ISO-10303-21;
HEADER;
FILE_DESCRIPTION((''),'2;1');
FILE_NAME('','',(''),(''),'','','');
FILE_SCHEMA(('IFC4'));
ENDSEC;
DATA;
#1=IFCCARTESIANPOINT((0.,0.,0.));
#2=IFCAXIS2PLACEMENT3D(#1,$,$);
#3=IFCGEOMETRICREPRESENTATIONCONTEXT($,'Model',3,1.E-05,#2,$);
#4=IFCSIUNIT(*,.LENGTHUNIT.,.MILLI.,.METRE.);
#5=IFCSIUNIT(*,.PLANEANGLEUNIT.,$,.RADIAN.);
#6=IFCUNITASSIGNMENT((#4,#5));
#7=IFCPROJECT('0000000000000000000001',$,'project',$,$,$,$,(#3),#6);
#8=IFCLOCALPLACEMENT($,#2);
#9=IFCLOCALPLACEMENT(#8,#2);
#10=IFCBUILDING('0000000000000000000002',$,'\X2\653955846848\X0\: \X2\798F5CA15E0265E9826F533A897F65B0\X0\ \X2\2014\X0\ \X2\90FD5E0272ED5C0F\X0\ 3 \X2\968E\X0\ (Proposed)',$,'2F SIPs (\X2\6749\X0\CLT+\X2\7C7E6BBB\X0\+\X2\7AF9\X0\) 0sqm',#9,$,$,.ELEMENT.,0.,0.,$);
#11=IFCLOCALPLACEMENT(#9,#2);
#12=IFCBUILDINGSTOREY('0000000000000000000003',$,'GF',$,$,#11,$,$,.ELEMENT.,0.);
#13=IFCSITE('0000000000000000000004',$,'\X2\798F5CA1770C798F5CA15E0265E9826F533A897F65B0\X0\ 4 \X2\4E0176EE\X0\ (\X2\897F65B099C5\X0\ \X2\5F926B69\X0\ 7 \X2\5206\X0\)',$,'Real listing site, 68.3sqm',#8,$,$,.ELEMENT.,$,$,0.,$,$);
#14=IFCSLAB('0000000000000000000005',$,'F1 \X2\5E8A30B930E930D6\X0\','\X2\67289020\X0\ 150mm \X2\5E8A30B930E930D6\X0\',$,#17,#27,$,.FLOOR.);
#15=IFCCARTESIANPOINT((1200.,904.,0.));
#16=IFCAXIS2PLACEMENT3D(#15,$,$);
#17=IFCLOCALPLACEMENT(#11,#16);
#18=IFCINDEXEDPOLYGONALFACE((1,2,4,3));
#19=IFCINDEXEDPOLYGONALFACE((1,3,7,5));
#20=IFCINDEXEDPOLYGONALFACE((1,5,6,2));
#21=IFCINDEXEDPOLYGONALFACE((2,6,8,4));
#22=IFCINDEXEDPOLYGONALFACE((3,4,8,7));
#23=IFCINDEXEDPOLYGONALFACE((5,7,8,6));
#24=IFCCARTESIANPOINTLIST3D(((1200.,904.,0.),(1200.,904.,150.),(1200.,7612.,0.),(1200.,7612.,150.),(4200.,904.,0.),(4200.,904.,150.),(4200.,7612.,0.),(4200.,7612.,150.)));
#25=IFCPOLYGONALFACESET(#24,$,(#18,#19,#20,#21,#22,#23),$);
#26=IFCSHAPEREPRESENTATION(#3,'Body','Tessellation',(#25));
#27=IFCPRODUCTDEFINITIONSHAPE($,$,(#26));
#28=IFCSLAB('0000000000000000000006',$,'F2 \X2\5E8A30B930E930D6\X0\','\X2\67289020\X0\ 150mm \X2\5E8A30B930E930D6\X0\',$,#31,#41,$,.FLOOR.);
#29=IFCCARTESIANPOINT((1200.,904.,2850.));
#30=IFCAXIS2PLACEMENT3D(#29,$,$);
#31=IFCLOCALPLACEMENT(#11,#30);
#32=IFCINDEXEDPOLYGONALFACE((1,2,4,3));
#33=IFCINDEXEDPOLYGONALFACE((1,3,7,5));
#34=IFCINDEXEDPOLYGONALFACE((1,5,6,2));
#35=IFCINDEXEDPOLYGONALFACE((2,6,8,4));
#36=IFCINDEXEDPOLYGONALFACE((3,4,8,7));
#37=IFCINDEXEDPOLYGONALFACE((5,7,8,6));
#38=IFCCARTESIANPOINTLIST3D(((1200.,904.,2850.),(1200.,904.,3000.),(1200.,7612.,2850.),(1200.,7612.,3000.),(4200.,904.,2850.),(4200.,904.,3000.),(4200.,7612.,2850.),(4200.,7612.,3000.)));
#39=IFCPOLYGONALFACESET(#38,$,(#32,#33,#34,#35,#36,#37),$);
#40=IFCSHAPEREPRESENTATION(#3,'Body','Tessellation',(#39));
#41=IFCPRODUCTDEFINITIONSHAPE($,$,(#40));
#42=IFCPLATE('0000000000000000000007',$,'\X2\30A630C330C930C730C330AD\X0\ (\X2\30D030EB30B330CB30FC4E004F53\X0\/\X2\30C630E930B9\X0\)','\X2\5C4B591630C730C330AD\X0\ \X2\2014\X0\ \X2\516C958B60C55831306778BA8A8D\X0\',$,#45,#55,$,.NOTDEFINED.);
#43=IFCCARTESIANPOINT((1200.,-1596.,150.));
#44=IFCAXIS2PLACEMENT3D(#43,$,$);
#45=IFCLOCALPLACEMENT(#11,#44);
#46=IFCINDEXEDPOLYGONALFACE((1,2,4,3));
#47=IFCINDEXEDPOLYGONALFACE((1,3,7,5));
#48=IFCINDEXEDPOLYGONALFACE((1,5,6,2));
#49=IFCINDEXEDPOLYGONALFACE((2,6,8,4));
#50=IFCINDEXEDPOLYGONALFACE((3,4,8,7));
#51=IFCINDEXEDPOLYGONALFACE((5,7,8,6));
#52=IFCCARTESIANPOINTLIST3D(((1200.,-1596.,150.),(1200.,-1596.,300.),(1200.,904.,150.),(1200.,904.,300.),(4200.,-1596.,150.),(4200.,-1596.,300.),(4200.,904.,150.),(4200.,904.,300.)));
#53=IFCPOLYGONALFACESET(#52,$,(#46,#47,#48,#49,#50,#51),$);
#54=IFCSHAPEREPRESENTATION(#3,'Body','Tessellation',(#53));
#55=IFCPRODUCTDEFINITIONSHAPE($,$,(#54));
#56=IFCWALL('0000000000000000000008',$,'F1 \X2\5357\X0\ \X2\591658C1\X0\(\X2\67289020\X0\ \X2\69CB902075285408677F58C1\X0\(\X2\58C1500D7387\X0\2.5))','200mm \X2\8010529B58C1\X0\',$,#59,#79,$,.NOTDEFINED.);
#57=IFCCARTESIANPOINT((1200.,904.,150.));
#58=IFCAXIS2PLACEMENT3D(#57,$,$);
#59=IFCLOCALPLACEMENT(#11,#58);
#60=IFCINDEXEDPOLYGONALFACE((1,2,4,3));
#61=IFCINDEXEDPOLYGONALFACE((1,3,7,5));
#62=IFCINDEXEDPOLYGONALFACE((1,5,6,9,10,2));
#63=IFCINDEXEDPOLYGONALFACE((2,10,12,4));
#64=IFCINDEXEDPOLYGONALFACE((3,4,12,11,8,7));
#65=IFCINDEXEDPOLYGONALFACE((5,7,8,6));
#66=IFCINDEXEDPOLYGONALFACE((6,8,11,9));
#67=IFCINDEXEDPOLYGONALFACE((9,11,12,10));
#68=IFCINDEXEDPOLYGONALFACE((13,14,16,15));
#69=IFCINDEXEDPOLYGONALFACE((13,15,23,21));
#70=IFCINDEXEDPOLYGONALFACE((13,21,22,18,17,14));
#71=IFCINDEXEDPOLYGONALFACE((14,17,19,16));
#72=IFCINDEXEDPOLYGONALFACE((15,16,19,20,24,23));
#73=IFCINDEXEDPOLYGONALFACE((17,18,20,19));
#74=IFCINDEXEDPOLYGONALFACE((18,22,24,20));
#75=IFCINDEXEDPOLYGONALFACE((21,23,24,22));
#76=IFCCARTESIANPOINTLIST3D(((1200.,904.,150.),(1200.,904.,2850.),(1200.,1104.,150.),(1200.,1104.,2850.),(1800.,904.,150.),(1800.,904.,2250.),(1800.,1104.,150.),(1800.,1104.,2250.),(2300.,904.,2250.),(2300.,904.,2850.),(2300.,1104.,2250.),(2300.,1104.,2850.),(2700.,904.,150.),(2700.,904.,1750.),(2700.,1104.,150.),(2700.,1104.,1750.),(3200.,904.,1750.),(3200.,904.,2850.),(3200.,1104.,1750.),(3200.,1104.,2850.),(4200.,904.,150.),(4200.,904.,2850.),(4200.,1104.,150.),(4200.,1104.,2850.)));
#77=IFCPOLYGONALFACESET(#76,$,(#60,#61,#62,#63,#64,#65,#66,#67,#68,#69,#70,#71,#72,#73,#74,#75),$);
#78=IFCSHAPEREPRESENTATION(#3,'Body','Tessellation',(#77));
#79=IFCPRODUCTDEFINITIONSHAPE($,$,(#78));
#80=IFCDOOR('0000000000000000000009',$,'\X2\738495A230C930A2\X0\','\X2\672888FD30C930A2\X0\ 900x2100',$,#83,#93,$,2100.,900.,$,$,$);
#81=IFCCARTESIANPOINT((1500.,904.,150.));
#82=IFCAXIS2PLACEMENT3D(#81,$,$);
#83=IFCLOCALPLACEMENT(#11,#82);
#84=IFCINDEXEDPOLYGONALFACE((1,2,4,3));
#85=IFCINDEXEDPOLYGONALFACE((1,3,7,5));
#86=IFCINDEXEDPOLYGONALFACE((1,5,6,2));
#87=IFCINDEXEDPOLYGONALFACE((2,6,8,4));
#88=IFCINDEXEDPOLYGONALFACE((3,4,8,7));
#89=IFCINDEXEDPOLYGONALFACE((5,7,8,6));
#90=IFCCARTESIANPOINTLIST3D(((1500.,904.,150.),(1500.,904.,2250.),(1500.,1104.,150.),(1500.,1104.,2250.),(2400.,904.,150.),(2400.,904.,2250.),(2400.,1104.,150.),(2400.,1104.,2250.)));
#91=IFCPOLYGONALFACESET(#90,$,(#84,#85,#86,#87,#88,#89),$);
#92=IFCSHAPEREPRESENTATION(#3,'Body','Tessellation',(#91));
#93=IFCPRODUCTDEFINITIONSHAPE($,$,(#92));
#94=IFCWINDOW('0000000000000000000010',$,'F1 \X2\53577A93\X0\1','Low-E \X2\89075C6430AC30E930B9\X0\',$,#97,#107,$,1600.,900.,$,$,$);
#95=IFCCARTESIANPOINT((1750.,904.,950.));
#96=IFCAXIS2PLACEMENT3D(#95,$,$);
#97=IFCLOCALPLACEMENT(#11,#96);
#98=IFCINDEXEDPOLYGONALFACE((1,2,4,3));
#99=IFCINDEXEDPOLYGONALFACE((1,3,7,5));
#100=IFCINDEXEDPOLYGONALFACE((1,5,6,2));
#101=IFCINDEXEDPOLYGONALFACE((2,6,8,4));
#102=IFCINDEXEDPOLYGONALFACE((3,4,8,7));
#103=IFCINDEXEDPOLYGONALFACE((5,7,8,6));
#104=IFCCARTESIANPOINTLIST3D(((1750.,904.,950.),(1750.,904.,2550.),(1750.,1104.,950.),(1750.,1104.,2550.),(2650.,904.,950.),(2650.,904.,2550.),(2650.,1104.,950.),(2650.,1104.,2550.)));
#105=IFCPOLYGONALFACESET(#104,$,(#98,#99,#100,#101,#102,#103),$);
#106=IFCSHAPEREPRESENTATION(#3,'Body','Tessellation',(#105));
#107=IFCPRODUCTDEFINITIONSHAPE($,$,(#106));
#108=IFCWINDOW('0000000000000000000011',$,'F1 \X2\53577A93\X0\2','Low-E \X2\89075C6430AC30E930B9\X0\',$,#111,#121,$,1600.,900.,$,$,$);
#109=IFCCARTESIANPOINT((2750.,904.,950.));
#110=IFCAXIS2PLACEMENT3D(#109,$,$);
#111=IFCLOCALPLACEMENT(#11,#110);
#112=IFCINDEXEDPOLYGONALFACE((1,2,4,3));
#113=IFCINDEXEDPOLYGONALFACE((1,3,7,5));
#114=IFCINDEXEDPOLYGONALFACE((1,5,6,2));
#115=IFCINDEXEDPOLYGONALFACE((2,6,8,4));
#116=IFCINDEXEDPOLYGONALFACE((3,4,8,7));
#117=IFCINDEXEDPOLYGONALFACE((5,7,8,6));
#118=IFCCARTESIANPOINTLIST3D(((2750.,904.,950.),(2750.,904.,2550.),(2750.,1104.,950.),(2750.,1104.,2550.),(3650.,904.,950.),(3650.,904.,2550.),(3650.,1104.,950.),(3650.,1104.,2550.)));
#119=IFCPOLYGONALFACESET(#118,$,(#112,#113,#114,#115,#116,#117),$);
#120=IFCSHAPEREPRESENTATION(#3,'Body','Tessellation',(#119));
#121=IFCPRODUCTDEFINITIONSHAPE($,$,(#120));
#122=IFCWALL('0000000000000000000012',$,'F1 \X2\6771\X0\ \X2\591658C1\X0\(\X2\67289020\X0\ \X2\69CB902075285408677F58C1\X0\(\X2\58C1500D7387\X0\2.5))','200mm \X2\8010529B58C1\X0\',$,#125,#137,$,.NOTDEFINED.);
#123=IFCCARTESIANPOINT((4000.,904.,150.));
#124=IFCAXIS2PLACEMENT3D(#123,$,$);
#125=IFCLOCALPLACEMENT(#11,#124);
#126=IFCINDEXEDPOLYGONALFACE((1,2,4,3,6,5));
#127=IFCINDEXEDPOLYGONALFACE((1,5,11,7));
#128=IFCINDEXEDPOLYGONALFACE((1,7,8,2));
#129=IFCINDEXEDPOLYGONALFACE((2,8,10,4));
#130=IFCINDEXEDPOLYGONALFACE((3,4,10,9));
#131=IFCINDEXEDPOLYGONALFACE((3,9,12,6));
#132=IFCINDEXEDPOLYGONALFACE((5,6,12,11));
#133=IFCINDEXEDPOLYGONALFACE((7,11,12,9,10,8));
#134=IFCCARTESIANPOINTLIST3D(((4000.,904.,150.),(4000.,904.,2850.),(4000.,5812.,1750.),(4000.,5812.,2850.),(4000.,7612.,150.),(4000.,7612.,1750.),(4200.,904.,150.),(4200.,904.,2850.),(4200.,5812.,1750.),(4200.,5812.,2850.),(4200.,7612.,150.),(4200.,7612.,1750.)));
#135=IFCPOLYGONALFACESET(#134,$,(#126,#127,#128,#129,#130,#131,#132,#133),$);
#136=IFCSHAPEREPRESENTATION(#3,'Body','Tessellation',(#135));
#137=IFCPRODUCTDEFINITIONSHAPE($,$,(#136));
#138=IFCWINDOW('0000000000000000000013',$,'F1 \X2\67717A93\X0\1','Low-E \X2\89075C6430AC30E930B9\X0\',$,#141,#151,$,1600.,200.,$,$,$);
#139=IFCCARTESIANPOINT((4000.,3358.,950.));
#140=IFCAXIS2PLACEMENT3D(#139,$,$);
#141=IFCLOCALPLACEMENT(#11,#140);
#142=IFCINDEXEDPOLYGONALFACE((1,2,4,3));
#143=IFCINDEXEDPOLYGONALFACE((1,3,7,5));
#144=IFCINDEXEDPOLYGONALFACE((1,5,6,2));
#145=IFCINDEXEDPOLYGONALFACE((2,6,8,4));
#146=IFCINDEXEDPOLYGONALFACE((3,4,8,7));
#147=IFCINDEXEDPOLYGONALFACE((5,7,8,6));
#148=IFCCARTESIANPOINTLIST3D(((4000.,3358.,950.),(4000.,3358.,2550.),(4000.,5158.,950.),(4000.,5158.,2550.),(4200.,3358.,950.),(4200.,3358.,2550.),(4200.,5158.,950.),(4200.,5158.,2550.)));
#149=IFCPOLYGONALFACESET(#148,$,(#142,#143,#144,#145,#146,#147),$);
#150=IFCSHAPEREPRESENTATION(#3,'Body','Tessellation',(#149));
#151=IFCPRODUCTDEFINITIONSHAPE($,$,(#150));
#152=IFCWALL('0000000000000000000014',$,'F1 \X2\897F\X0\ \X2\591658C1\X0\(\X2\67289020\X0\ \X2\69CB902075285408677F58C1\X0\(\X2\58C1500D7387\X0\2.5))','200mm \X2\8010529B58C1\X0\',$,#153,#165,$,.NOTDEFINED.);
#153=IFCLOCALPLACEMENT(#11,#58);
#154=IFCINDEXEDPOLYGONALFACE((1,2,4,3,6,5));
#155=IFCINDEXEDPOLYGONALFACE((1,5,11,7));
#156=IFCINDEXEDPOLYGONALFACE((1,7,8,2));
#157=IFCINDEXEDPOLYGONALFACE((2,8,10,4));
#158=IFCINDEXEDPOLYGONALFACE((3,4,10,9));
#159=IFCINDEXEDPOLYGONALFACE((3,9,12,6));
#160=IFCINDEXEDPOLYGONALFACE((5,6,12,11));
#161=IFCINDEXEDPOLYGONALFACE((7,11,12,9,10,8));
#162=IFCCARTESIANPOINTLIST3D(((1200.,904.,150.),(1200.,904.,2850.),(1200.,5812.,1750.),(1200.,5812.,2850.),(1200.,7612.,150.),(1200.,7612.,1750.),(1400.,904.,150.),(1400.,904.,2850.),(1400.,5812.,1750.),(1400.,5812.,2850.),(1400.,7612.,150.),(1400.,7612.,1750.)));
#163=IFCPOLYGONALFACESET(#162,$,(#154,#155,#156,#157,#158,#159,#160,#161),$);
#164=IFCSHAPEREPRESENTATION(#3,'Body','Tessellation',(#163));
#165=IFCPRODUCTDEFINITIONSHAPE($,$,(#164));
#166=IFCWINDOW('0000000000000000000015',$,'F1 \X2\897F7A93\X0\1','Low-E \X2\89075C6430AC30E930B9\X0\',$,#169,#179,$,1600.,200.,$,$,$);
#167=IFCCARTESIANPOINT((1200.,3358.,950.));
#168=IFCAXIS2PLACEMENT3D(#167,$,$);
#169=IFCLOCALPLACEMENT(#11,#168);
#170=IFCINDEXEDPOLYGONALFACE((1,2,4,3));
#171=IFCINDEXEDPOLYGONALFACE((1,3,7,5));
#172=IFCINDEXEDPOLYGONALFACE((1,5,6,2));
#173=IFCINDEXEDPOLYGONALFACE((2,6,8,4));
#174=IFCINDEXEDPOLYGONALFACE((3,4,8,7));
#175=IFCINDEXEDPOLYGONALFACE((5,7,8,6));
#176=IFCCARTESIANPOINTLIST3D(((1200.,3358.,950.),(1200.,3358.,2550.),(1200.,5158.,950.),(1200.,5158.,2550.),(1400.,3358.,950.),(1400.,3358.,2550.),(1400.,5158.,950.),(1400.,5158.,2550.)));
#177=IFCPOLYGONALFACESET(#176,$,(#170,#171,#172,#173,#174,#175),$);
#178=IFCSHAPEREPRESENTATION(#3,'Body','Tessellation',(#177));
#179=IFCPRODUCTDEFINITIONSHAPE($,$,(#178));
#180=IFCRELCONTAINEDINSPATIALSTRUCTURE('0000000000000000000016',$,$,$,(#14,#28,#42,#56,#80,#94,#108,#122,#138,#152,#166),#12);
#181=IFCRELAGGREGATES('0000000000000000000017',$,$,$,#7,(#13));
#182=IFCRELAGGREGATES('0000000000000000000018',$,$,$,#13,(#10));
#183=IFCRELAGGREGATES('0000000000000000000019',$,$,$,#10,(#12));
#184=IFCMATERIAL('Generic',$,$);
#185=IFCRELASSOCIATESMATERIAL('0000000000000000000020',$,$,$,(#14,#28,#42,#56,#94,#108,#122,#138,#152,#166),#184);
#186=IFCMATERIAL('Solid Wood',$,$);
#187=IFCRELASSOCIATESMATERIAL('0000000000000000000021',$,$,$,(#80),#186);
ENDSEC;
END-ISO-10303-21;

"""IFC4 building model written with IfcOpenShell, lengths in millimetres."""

from ifc_helpers import new_model, si_unit, frame, frame_2d, origin, place, context, project, spatial, rectangle, extrude, material, element, fill, save


model = new_model("IFC4")

# Units and contexts
model_context = context("Model", 3, precision=1e-05, world=origin())
ifc_project = project(units=[si_unit("LENGTHUNIT", "METRE", prefix="MILLI"), si_unit("PLANEANGLEUNIT", "RADIAN")], contexts=[model_context])

# Site, building, storey
site_placement = place(None, origin())
site = spatial("IfcSite", under=ifc_project, at=site_placement, Name="福岡県福岡市早良区西新 4 丁目 (西新駅 徒歩 7 分)", ObjectType="Real listing site, 68.3sqm", CompositionType="ELEMENT", RefElevation=0.0)
building_placement = place(site_placement, origin())
building = spatial("IfcBuilding", under=site, at=building_placement, Name="改善案: 福岡市早良区西新 — 都市狭小 3 階 (Proposed)", ObjectType="2F SIPs (杉CLT+籾殻+竹) 0sqm", CompositionType="ELEMENT", ElevationOfRefHeight=0.0, ElevationOfTerrain=0.0)
storey_placement = place(building_placement, origin())
storey = spatial("IfcBuildingStorey", under=building, at=storey_placement, Name="GF", CompositionType="ELEMENT", Elevation=0.0)

# Slabs
ifc_material_1 = material(Name="Generic")
slab_1_placement = place(storey_placement, frame((1200.0, 904.0, 0.0)))
element("IfcSlab", 1, at=slab_1_placement, inside=storey, material=ifc_material_1, Name="F1 床スラブ", Description="木造 150mm 床スラブ", PredefinedType="FLOOR", context=model_context, shape_type="SweptSolid", body=[
    extrude(rectangle(XDim=3000.0, YDim=6708.0, at=frame_2d((1500.0, 3354.0))), frame((1200.0, 904.0, 0.0)), (0.0, 0.0, 1.0), 150.0),
])
slab_2_placement = place(storey_placement, frame((1200.0, 904.0, 2850.0)))
element("IfcSlab", 2, at=slab_2_placement, inside=storey, material=ifc_material_1, Name="F2 床スラブ", Description="木造 150mm 床スラブ", PredefinedType="FLOOR", context=model_context, shape_type="SweptSolid", body=[
    extrude(rectangle(XDim=3000.0, YDim=6708.0, at=frame_2d((1500.0, 3354.0))), frame((1200.0, 904.0, 2850.0)), (0.0, 0.0, 1.0), 150.0),
])

# Plate
plate_placement = place(storey_placement, frame((1200.0, -1596.0, 150.0)))
element("IfcPlate", 3, at=plate_placement, inside=storey, material=ifc_material_1, Name="ウッドデッキ (バルコニー一体/テラス)", Description="屋外デッキ — 公開情報で確認", PredefinedType="NOTDEFINED", context=model_context, shape_type="SweptSolid", body=[
    extrude(rectangle(XDim=3000.0, YDim=2500.0, at=frame_2d((1500.0, 1250.0))), frame((1200.0, -1596.0, 150.0)), (0.0, 0.0, 1.0), 150.0),
])

# Wall, openings, door, windows
wall_1_placement = place(storey_placement, frame((1200.0, 904.0, 150.0)))
wall_1 = element("IfcWall", 4, at=wall_1_placement, inside=storey, material=ifc_material_1, Name="F1 南 外壁(木造 構造用合板壁(壁倍率2.5))", Description="200mm 耐力壁", PredefinedType="NOTDEFINED", context=model_context, shape_type="SweptSolid", body=[
    extrude(rectangle(XDim=3000.0, YDim=200.0, at=frame_2d((1500.0, 100.0))), frame((1200.0, 904.0, 150.0)), (0.0, 0.0, 1.0), 2700.0),
])
opening_1_placement = place(storey_placement, frame((1500.0, 904.0, 150.0)))
opening_1 = element("IfcOpeningElement", 5, at=opening_1_placement, cuts=wall_1, PredefinedType="NOTDEFINED", context=model_context, shape_type="SweptSolid", body=[
    extrude(rectangle(XDim=900.0, YDim=200.0, at=frame_2d((450.0, 100.0))), frame((1500.0, 904.0, 150.0)), (0.0, 0.0, 1.0), 2100.0),
])
opening_2_placement = place(storey_placement, frame((1750.0, 904.0, 950.0)))
opening_2 = element("IfcOpeningElement", 6, at=opening_2_placement, cuts=wall_1, PredefinedType="NOTDEFINED", context=model_context, shape_type="SweptSolid", body=[
    extrude(rectangle(XDim=900.0, YDim=200.0, at=frame_2d((450.0, 100.0))), frame((1750.0, 904.0, 950.0)), (0.0, 0.0, 1.0), 1600.0),
])
opening_3_placement = place(storey_placement, frame((2750.0, 904.0, 950.0)))
opening_3 = element("IfcOpeningElement", 7, at=opening_3_placement, cuts=wall_1, PredefinedType="NOTDEFINED", context=model_context, shape_type="SweptSolid", body=[
    extrude(rectangle(XDim=900.0, YDim=200.0, at=frame_2d((450.0, 100.0))), frame((2750.0, 904.0, 950.0)), (0.0, 0.0, 1.0), 1600.0),
])
ifc_material_2 = material(Name="Solid Wood")
door_placement = place(storey_placement, frame((1500.0, 904.0, 150.0)))
door = element("IfcDoor", 8, at=door_placement, inside=storey, material=ifc_material_2, Name="玄関ドア", Description="木製ドア 900x2100", OverallHeight=2100.0, OverallWidth=900.0, context=model_context, shape_type="SweptSolid", body=[
    extrude(rectangle(XDim=900.0, YDim=200.0, at=frame_2d((450.0, 100.0))), frame((1500.0, 904.0, 150.0)), (0.0, 0.0, 1.0), 2100.0),
])
fill(opening_1, door)
window_1_placement = place(storey_placement, frame((1750.0, 904.0, 950.0)))
window_1 = element("IfcWindow", 9, at=window_1_placement, inside=storey, material=ifc_material_1, Name="F1 南窓1", Description="Low-E 複層ガラス", OverallHeight=1600.0, OverallWidth=900.0, context=model_context, shape_type="SweptSolid", body=[
    extrude(rectangle(XDim=900.0, YDim=200.0, at=frame_2d((450.0, 100.0))), frame((1750.0, 904.0, 950.0)), (0.0, 0.0, 1.0), 1600.0),
])
fill(opening_2, window_1)
window_2_placement = place(storey_placement, frame((2750.0, 904.0, 950.0)))
window_2 = element("IfcWindow", 10, at=window_2_placement, inside=storey, material=ifc_material_1, Name="F1 南窓2", Description="Low-E 複層ガラス", OverallHeight=1600.0, OverallWidth=900.0, context=model_context, shape_type="SweptSolid", body=[
    extrude(rectangle(XDim=900.0, YDim=200.0, at=frame_2d((450.0, 100.0))), frame((2750.0, 904.0, 950.0)), (0.0, 0.0, 1.0), 1600.0),
])
fill(opening_3, window_2)

# Walls, openings, windows
wall_2_placement = place(storey_placement, frame((4000.0, 904.0, 150.0)))
wall_2 = element("IfcWall", 11, at=wall_2_placement, inside=storey, material=ifc_material_1, Name="F1 東 外壁(木造 構造用合板壁(壁倍率2.5))", Description="200mm 耐力壁", PredefinedType="NOTDEFINED", context=model_context, shape_type="SweptSolid", body=[
    extrude(rectangle(XDim=200.0, YDim=6708.0, at=frame_2d((100.0, 3354.0))), frame((4000.0, 904.0, 150.0)), (0.0, 0.0, 1.0), 2700.0),
])
opening_4_placement = place(storey_placement, frame((4000.0, 3358.0, 950.0)))
opening_4 = element("IfcOpeningElement", 12, at=opening_4_placement, cuts=wall_2, PredefinedType="NOTDEFINED", context=model_context, shape_type="SweptSolid", body=[
    extrude(rectangle(XDim=200.0, YDim=1800.0, at=frame_2d((100.0, 900.0))), frame((4000.0, 3358.0, 950.0)), (0.0, 0.0, 1.0), 1600.0),
])
window_3_placement = place(storey_placement, frame((4000.0, 3358.0, 950.0)))
window_3 = element("IfcWindow", 13, at=window_3_placement, inside=storey, material=ifc_material_1, Name="F1 東窓1", Description="Low-E 複層ガラス", OverallHeight=1600.0, OverallWidth=200.0, context=model_context, shape_type="SweptSolid", body=[
    extrude(rectangle(XDim=200.0, YDim=1800.0, at=frame_2d((100.0, 900.0))), frame((4000.0, 3358.0, 950.0)), (0.0, 0.0, 1.0), 1600.0),
])
fill(opening_4, window_3)
wall_3_placement = place(storey_placement, frame((1200.0, 904.0, 150.0)))
wall_3 = element("IfcWall", 14, at=wall_3_placement, inside=storey, material=ifc_material_1, Name="F1 西 外壁(木造 構造用合板壁(壁倍率2.5))", Description="200mm 耐力壁", PredefinedType="NOTDEFINED", context=model_context, shape_type="SweptSolid", body=[
    extrude(rectangle(XDim=200.0, YDim=6708.0, at=frame_2d((100.0, 3354.0))), frame((1200.0, 904.0, 150.0)), (0.0, 0.0, 1.0), 2700.0),
])
opening_5_placement = place(storey_placement, frame((1200.0, 3358.0, 950.0)))
opening_5 = element("IfcOpeningElement", 15, at=opening_5_placement, cuts=wall_3, PredefinedType="NOTDEFINED", context=model_context, shape_type="SweptSolid", body=[
    extrude(rectangle(XDim=200.0, YDim=1800.0, at=frame_2d((100.0, 900.0))), frame((1200.0, 3358.0, 950.0)), (0.0, 0.0, 1.0), 1600.0),
])
window_4_placement = place(storey_placement, frame((1200.0, 3358.0, 950.0)))
window_4 = element("IfcWindow", 16, at=window_4_placement, inside=storey, material=ifc_material_1, Name="F1 西窓1", Description="Low-E 複層ガラス", OverallHeight=1600.0, OverallWidth=200.0, context=model_context, shape_type="SweptSolid", body=[
    extrude(rectangle(XDim=200.0, YDim=1800.0, at=frame_2d((100.0, 900.0))), frame((1200.0, 3358.0, 950.0)), (0.0, 0.0, 1.0), 1600.0),
])
fill(opening_5, window_4)

save(model, "model.ifc")
